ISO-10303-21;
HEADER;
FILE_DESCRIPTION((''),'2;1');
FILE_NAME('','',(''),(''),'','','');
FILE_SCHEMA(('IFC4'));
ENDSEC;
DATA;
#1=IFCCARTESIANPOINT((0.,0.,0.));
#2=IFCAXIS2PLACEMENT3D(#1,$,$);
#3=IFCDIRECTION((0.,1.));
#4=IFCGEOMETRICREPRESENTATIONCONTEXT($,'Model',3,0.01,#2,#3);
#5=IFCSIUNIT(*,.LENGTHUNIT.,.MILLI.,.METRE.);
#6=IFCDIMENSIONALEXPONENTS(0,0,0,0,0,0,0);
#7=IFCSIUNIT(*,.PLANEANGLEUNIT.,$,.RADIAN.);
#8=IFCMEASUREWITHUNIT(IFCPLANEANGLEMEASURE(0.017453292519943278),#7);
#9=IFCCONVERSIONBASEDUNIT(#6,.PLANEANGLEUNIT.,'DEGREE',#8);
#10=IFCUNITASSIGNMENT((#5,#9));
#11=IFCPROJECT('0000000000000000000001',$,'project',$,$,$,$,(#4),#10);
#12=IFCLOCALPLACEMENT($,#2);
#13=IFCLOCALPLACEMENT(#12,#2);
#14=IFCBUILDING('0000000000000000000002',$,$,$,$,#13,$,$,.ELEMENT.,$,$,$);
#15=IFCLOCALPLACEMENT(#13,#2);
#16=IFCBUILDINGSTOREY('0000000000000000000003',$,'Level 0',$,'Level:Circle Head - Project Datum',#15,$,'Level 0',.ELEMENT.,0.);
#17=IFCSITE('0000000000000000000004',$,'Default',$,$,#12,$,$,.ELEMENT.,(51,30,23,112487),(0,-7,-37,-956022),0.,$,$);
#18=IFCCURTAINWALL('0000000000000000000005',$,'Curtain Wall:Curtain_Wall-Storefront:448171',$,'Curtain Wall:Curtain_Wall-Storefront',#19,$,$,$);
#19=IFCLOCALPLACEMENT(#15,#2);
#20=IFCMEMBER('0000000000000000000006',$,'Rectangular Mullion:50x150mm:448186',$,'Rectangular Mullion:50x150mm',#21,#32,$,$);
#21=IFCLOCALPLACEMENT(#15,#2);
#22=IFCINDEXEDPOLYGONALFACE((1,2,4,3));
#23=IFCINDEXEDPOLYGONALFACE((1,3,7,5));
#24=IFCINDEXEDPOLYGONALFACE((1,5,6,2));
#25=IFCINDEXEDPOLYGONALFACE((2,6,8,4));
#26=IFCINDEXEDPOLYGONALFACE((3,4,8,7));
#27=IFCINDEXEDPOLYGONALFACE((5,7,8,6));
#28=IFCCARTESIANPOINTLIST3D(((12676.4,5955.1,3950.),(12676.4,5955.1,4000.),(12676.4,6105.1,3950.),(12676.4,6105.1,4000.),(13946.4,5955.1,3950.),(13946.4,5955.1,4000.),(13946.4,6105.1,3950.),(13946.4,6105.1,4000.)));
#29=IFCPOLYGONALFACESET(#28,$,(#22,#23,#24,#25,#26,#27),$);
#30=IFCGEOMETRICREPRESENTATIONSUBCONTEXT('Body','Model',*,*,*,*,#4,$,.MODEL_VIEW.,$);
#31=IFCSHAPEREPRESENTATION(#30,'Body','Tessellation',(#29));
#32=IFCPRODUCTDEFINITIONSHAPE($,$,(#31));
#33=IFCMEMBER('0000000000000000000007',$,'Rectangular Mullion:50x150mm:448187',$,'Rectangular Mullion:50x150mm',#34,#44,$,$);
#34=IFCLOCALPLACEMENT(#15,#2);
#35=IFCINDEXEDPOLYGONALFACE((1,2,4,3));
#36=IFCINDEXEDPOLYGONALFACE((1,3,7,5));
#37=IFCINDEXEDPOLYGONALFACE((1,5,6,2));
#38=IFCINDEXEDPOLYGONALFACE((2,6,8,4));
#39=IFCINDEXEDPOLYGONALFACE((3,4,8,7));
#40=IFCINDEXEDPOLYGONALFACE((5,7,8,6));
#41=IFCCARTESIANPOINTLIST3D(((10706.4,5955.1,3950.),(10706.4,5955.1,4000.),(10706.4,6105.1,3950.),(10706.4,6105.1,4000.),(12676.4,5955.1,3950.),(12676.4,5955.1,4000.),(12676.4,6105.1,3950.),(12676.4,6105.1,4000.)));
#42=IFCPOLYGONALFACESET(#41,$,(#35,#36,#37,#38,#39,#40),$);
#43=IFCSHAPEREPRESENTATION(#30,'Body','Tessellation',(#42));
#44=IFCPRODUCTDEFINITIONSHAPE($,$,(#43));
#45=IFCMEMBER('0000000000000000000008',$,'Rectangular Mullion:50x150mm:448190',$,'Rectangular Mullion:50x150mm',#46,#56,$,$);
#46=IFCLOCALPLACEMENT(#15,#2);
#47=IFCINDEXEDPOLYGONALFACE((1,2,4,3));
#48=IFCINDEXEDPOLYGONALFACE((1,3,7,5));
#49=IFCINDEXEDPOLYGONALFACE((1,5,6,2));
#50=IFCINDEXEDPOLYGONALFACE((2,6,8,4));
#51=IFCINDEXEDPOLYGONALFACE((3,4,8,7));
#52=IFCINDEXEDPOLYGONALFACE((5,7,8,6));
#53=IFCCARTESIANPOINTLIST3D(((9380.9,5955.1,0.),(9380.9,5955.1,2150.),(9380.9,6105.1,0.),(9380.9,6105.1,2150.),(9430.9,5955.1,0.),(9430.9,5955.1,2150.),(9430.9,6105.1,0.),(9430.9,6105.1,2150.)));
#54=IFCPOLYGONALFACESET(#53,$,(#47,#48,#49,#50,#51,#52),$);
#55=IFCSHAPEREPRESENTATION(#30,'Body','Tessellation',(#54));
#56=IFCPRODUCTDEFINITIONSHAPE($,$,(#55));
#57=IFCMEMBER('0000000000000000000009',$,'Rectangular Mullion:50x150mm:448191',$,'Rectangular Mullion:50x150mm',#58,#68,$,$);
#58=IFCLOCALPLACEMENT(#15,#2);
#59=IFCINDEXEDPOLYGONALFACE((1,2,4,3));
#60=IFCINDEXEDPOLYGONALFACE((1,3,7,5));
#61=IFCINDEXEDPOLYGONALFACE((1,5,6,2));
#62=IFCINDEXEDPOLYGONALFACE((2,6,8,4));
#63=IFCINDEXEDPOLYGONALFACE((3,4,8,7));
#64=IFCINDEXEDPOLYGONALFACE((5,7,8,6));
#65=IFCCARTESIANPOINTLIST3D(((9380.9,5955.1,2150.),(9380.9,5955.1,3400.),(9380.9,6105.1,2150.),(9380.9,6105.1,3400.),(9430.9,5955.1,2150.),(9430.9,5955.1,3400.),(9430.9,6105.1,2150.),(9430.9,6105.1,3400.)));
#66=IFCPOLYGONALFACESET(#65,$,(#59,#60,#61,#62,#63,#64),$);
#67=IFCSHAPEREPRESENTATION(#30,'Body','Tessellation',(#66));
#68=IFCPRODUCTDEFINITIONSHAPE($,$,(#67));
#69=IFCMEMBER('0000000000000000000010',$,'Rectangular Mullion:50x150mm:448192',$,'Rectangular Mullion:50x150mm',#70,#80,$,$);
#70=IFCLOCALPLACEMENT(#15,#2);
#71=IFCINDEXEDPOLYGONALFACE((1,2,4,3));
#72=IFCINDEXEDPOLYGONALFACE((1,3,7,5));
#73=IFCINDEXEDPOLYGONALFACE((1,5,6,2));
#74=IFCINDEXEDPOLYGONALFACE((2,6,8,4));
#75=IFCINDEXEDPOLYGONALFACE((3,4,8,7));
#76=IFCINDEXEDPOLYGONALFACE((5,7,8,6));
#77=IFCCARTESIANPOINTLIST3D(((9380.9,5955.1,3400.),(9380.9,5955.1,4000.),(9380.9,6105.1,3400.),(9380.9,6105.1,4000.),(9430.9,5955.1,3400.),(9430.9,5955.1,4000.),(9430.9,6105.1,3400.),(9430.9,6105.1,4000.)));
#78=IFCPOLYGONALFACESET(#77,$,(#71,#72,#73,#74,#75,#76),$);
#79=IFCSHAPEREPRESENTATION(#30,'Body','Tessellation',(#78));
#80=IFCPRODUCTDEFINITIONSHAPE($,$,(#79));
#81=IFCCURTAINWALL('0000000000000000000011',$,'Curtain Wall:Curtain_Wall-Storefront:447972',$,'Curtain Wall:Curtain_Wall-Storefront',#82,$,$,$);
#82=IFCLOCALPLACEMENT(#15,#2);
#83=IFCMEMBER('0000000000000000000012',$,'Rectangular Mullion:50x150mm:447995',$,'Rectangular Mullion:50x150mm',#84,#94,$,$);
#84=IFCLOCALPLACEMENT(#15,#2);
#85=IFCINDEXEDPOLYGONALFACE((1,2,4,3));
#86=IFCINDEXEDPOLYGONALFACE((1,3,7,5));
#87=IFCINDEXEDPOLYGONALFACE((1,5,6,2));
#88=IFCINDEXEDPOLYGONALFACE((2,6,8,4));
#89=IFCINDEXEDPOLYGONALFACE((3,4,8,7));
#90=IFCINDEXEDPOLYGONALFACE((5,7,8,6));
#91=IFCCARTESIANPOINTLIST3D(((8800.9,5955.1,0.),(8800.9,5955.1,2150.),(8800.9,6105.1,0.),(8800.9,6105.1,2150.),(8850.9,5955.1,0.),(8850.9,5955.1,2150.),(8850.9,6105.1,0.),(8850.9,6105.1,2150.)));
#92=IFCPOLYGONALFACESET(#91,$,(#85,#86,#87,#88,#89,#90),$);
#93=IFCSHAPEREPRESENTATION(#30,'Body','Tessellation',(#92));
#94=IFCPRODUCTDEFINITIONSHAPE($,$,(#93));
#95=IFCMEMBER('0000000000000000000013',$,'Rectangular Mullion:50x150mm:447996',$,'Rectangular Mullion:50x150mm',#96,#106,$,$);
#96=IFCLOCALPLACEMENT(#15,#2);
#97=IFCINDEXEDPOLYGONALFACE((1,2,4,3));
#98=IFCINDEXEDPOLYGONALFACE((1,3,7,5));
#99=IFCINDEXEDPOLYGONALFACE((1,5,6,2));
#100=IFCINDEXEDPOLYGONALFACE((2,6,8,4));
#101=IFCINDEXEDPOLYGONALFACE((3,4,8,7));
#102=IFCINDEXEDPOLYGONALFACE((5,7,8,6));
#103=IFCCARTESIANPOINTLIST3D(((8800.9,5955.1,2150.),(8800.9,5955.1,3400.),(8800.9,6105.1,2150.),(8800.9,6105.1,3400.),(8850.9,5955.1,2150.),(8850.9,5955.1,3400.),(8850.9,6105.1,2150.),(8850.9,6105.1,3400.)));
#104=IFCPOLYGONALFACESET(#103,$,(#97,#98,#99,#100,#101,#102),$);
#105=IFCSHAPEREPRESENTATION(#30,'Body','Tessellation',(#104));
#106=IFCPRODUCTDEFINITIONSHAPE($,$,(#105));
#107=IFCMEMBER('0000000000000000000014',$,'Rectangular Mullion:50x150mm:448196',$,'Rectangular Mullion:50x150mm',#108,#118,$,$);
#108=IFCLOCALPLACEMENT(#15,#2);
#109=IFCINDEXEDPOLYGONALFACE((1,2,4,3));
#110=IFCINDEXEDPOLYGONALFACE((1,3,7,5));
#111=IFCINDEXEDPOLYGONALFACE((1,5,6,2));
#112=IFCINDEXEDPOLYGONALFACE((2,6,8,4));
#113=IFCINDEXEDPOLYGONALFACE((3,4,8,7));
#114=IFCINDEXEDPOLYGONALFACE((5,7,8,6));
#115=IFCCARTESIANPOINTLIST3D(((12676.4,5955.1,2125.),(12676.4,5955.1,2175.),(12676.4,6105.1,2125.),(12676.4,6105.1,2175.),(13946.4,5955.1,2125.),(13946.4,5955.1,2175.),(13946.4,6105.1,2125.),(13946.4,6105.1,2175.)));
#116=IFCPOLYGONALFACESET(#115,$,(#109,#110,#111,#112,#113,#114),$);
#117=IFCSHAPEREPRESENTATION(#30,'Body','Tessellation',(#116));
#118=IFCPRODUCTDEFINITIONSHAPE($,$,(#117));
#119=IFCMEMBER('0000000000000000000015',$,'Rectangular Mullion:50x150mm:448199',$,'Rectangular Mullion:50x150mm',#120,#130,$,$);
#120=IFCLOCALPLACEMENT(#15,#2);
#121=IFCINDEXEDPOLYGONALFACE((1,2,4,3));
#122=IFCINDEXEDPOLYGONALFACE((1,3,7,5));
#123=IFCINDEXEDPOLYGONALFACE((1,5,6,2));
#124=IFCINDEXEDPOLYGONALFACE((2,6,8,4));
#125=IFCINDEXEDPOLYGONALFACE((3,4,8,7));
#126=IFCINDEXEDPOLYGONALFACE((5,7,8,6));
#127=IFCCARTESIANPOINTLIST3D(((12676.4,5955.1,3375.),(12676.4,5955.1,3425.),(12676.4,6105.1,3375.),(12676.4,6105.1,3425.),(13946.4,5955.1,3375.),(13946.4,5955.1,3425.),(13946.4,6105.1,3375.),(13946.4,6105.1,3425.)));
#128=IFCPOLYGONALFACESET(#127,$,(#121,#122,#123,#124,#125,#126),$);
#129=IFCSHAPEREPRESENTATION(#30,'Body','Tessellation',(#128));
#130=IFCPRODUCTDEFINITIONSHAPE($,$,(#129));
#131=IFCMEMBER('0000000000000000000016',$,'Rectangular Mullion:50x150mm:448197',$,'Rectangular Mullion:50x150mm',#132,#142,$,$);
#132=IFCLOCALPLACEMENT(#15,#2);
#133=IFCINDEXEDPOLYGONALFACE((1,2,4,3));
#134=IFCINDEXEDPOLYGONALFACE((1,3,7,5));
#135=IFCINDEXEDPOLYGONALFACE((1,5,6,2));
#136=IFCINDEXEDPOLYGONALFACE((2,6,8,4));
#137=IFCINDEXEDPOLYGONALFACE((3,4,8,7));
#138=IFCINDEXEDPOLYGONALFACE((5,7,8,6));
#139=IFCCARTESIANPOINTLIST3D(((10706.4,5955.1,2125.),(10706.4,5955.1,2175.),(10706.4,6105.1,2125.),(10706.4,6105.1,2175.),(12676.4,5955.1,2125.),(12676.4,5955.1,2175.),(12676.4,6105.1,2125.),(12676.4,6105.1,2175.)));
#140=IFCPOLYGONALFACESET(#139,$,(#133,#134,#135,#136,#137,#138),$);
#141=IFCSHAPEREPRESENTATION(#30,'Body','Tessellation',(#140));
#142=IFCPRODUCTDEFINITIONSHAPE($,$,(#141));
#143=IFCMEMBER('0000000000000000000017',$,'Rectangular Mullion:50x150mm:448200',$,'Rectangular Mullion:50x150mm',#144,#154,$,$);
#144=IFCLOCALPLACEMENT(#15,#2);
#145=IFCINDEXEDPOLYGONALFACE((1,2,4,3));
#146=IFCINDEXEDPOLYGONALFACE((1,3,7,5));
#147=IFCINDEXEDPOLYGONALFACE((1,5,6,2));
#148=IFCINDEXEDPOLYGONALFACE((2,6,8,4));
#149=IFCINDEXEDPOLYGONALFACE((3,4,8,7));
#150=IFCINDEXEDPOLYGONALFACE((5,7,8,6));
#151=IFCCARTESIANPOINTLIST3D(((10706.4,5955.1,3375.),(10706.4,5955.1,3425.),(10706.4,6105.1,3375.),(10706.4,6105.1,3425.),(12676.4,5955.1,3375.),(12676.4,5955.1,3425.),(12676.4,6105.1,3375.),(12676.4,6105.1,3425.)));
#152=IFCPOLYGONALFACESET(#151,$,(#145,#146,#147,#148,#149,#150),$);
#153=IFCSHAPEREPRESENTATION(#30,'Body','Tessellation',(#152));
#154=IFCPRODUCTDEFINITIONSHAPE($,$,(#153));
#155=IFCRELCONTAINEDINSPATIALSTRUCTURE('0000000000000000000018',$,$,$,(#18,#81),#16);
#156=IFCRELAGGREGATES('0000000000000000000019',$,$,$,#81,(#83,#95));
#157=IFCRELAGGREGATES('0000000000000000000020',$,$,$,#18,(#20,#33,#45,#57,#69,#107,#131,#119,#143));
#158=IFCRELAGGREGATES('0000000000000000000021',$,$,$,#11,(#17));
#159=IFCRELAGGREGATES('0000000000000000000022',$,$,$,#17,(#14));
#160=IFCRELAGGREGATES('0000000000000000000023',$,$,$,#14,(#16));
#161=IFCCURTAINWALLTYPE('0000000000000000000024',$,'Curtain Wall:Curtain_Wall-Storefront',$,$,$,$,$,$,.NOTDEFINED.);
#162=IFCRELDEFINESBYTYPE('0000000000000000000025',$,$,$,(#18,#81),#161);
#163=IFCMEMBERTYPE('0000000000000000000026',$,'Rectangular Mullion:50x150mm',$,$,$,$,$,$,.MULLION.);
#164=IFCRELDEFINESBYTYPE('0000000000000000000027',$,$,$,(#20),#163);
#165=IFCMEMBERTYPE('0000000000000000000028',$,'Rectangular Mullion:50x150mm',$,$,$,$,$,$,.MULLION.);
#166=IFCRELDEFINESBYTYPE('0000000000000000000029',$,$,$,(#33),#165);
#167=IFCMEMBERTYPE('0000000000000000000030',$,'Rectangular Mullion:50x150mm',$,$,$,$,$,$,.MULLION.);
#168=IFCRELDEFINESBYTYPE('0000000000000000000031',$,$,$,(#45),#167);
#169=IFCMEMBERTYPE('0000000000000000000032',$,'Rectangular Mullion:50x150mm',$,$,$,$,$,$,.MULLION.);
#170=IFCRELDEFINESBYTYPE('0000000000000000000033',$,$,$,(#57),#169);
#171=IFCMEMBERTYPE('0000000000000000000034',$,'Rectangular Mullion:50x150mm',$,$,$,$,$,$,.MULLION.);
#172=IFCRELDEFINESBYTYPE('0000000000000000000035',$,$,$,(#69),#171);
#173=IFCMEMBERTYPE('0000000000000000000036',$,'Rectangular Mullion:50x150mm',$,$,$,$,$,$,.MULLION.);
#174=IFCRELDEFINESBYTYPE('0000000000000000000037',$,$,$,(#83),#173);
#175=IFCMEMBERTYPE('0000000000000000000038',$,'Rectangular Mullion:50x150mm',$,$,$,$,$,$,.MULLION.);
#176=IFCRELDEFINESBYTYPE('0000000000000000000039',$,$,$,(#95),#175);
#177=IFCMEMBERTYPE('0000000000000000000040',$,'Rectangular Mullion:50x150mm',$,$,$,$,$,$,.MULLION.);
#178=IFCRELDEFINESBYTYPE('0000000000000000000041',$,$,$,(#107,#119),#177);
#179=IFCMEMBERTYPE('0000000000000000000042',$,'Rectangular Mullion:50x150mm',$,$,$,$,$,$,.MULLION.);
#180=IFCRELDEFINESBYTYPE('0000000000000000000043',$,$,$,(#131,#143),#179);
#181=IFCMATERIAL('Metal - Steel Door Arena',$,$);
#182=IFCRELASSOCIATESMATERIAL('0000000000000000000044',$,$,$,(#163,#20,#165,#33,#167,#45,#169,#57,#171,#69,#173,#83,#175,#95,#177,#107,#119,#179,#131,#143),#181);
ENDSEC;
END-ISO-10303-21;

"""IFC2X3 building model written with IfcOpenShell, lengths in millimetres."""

from ifc_helpers import new_model, entity, si_unit, converted_unit, direction, frame, origin, origin_2d_with_axis, place, context, subcontext, project, spatial, rectangle, extrude, source, transform, mapped, material, type_object, type_shapes, element, aggregate, save


model = new_model("IFC2X3")

# Units and contexts
model_context = context("Model", 3, precision=0.01, world=origin(), true_north=direction((0.0, 1.0)))
body_context = subcontext(model_context, "Body", "Model", "MODEL_VIEW")
ifc_project = project(units=[si_unit("LENGTHUNIT", "METRE", prefix="MILLI"), converted_unit("PLANEANGLEUNIT", "DEGREE", entity("IfcPlaneAngleMeasure", 0.017453292519943278), si_unit("PLANEANGLEUNIT", "RADIAN"), dimensions=[0, 0, 0, 0, 0, 0, 0])], contexts=[model_context])

# Site, building, storey
site_placement = place(None, origin())
site = spatial("IfcSite", under=ifc_project, at=site_placement, Name="Default", CompositionType="ELEMENT", RefLatitude=(51, 30, 23, 112487), RefLongitude=(0, -7, -37, -956022), RefElevation=0.0)
building_placement = place(site_placement, origin())
building = spatial("IfcBuilding", under=site, at=building_placement, CompositionType="ELEMENT")
storey_placement = place(building_placement, origin())
storey = spatial("IfcBuildingStorey", under=building, at=storey_placement, Name="Level 0", ObjectType="Level:Circle Head - Project Datum", LongName="Level 0", CompositionType="ELEMENT", Elevation=0.0)

# Curtain walls, members
curtain_wall_type = type_object("IfcCurtainWallType", Name="Curtain Wall:Curtain_Wall-Storefront", PredefinedType="NOTDEFINED")
curtain_wall_1_placement = place(storey_placement, origin())
curtain_wall_1 = element("IfcCurtainWall", 1, at=curtain_wall_1_placement, inside=storey, type_object=curtain_wall_type, Name="Curtain Wall:Curtain_Wall-Storefront:448171", ObjectType="Curtain Wall:Curtain_Wall-Storefront")
ifc_material_1 = material(Name="Metal - Steel Door Arena")
member_type_1 = type_object("IfcMemberType", Name="Rectangular Mullion:50x150mm", PredefinedType="MULLION", material=ifc_material_1)
shared_shape_1 = source(origin(), body_context, "Body", "SweptSolid", [
    extrude(rectangle(XDim=50.0, YDim=150.0, at=origin_2d_with_axis()), frame((-25.0, 0.0, -1270.0), z_axis=(0.0, 0.0, 1.0), x_axis=(-1.0, 0.0, 0.0)), (0.0, 0.0, 1.0), 1270.0),
])
type_shapes(member_type_1, [shared_shape_1])
member_1_placement = place(curtain_wall_1_placement, frame((12676.4, 6030.1, 4000.0), z_axis=(-1.0, 0.0, 0.0), x_axis=(0.0, 0.0, 1.0)))
member_1 = element("IfcMember", 2, at=member_1_placement, type_object=member_type_1, material=ifc_material_1, Name="Rectangular Mullion:50x150mm:448186", ObjectType="Rectangular Mullion:50x150mm", context=body_context, shape_type="MappedRepresentation", body=[
    mapped(shared_shape_1, transform((0.0, 0.0, 0.0), scale=1.0)),
])
member_type_2 = type_object("IfcMemberType", Name="Rectangular Mullion:50x150mm", PredefinedType="MULLION", material=ifc_material_1)
shared_shape_2 = source(origin(), body_context, "Body", "SweptSolid", [
    extrude(rectangle(XDim=50.0, YDim=150.0, at=origin_2d_with_axis()), frame((-25.0, 0.0, -1970.0), z_axis=(0.0, 0.0, 1.0), x_axis=(-1.0, 0.0, 0.0)), (0.0, 0.0, 1.0), 1970.0),
])
type_shapes(member_type_2, [shared_shape_2])
member_2_placement = place(curtain_wall_1_placement, frame((10706.4, 6030.1, 4000.0), z_axis=(-1.0, 0.0, 0.0), x_axis=(0.0, 0.0, 1.0)))
member_2 = element("IfcMember", 3, at=member_2_placement, type_object=member_type_2, material=ifc_material_1, Name="Rectangular Mullion:50x150mm:448187", ObjectType="Rectangular Mullion:50x150mm", context=body_context, shape_type="MappedRepresentation", body=[
    mapped(shared_shape_2, transform((0.0, 0.0, 0.0), scale=1.0)),
])
member_type_3 = type_object("IfcMemberType", Name="Rectangular Mullion:50x150mm", PredefinedType="MULLION", material=ifc_material_1)
shared_shape_3 = source(origin(), body_context, "Body", "SweptSolid", [
    extrude(rectangle(XDim=50.0, YDim=150.0, at=origin_2d_with_axis()), frame((-25.0, 0.0, -2150.0), z_axis=(0.0, 0.0, 1.0), x_axis=(-1.0, 0.0, 0.0)), (0.0, 0.0, 1.0), 2150.0),
])
type_shapes(member_type_3, [shared_shape_3])
member_3_placement = place(curtain_wall_1_placement, frame((9380.9, 6030.1, 0.0), z_axis=(0.0, 0.0, -1.0), x_axis=(-1.0, 0.0, 0.0)))
member_3 = element("IfcMember", 4, at=member_3_placement, type_object=member_type_3, material=ifc_material_1, Name="Rectangular Mullion:50x150mm:448190", ObjectType="Rectangular Mullion:50x150mm", context=body_context, shape_type="MappedRepresentation", body=[
    mapped(shared_shape_3, transform((0.0, 0.0, 0.0), scale=1.0)),
])
member_type_4 = type_object("IfcMemberType", Name="Rectangular Mullion:50x150mm", PredefinedType="MULLION", material=ifc_material_1)
shared_shape_4 = source(origin(), body_context, "Body", "SweptSolid", [
    extrude(rectangle(XDim=50.0, YDim=150.0, at=origin_2d_with_axis()), frame((-25.0, 0.0, -1250.0), z_axis=(0.0, 0.0, 1.0), x_axis=(-1.0, 0.0, 0.0)), (0.0, 0.0, 1.0), 1250.0),
])
type_shapes(member_type_4, [shared_shape_4])
member_4_placement = place(curtain_wall_1_placement, frame((9380.9, 6030.1, 2150.0), z_axis=(0.0, 0.0, -1.0), x_axis=(-1.0, 0.0, 0.0)))
member_4 = element("IfcMember", 5, at=member_4_placement, type_object=member_type_4, material=ifc_material_1, Name="Rectangular Mullion:50x150mm:448191", ObjectType="Rectangular Mullion:50x150mm", context=body_context, shape_type="MappedRepresentation", body=[
    mapped(shared_shape_4, transform((0.0, 0.0, 0.0), scale=1.0)),
])
member_type_5 = type_object("IfcMemberType", Name="Rectangular Mullion:50x150mm", PredefinedType="MULLION", material=ifc_material_1)
shared_shape_5 = source(origin(), body_context, "Body", "SweptSolid", [
    extrude(rectangle(XDim=50.0, YDim=150.0, at=origin_2d_with_axis()), frame((-25.0, 0.0, -600.0), z_axis=(0.0, 0.0, 1.0), x_axis=(-1.0, 0.0, 0.0)), (0.0, 0.0, 1.0), 600.0),
])
type_shapes(member_type_5, [shared_shape_5])
member_5_placement = place(curtain_wall_1_placement, frame((9380.9, 6030.1, 3400.0), z_axis=(0.0, 0.0, -1.0), x_axis=(-1.0, 0.0, 0.0)))
member_5 = element("IfcMember", 6, at=member_5_placement, type_object=member_type_5, material=ifc_material_1, Name="Rectangular Mullion:50x150mm:448192", ObjectType="Rectangular Mullion:50x150mm", context=body_context, shape_type="MappedRepresentation", body=[
    mapped(shared_shape_5, transform((0.0, 0.0, 0.0), scale=1.0)),
])
curtain_wall_2_placement = place(storey_placement, origin())
curtain_wall_2 = element("IfcCurtainWall", 7, at=curtain_wall_2_placement, inside=storey, type_object=curtain_wall_type, Name="Curtain Wall:Curtain_Wall-Storefront:447972", ObjectType="Curtain Wall:Curtain_Wall-Storefront")
member_type_6 = type_object("IfcMemberType", Name="Rectangular Mullion:50x150mm", PredefinedType="MULLION", material=ifc_material_1)
shared_shape_6 = source(origin(), body_context, "Body", "SweptSolid", [
    extrude(rectangle(XDim=50.0, YDim=150.0, at=origin_2d_with_axis()), frame((-25.0, 0.0, -2150.0), z_axis=(0.0, 0.0, 1.0), x_axis=(-1.0, 0.0, 0.0)), (0.0, 0.0, 1.0), 2150.0),
])
type_shapes(member_type_6, [shared_shape_6])
member_6_placement = place(curtain_wall_2_placement, frame((8850.9, 6030.1, 2150.0)))
member_6 = element("IfcMember", 8, at=member_6_placement, type_object=member_type_6, material=ifc_material_1, Name="Rectangular Mullion:50x150mm:447995", ObjectType="Rectangular Mullion:50x150mm", context=body_context, shape_type="MappedRepresentation", body=[
    mapped(shared_shape_6, transform((0.0, 0.0, 0.0), scale=1.0)),
])
member_type_7 = type_object("IfcMemberType", Name="Rectangular Mullion:50x150mm", PredefinedType="MULLION", material=ifc_material_1)
shared_shape_7 = source(origin(), body_context, "Body", "SweptSolid", [
    extrude(rectangle(XDim=50.0, YDim=150.0, at=origin_2d_with_axis()), frame((-25.0, 0.0, -1250.0), z_axis=(0.0, 0.0, 1.0), x_axis=(-1.0, 0.0, 0.0)), (0.0, 0.0, 1.0), 1250.0),
])
type_shapes(member_type_7, [shared_shape_7])
member_7_placement = place(curtain_wall_2_placement, frame((8850.9, 6030.1, 3400.0)))
member_7 = element("IfcMember", 9, at=member_7_placement, type_object=member_type_7, material=ifc_material_1, Name="Rectangular Mullion:50x150mm:447996", ObjectType="Rectangular Mullion:50x150mm", context=body_context, shape_type="MappedRepresentation", body=[
    mapped(shared_shape_7, transform((0.0, 0.0, 0.0), scale=1.0)),
])
aggregate(curtain_wall_2, [member_6, member_7])

# Members
member_type_8 = type_object("IfcMemberType", Name="Rectangular Mullion:50x150mm", PredefinedType="MULLION", material=ifc_material_1)
shared_shape_8 = source(origin(), body_context, "Body", "SweptSolid", [
    extrude(rectangle(XDim=50.0, YDim=150.0, at=origin_2d_with_axis()), frame((0.0, 0.0, -1270.0), z_axis=(0.0, 0.0, 1.0), x_axis=(-1.0, 0.0, 0.0)), (0.0, 0.0, 1.0), 1270.0),
])
type_shapes(member_type_8, [shared_shape_8])
member_8_placement = place(curtain_wall_1_placement, frame((12676.4, 6030.1, 2150.0), z_axis=(-1.0, 0.0, 0.0), x_axis=(0.0, 0.0, 1.0)))
member_8 = element("IfcMember", 10, at=member_8_placement, type_object=member_type_8, material=ifc_material_1, Name="Rectangular Mullion:50x150mm:448196", ObjectType="Rectangular Mullion:50x150mm", context=body_context, shape_type="MappedRepresentation", body=[
    mapped(shared_shape_8, transform((0.0, 0.0, 0.0), scale=1.0)),
])
member_9_placement = place(curtain_wall_1_placement, frame((12676.4, 6030.1, 3400.0), z_axis=(-1.0, 0.0, 0.0), x_axis=(0.0, 0.0, 1.0)))
member_9 = element("IfcMember", 11, at=member_9_placement, type_object=member_type_8, material=ifc_material_1, Name="Rectangular Mullion:50x150mm:448199", ObjectType="Rectangular Mullion:50x150mm", context=body_context, shape_type="MappedRepresentation", body=[
    mapped(shared_shape_8, transform((0.0, 0.0, 0.0), scale=1.0)),
])
member_type_9 = type_object("IfcMemberType", Name="Rectangular Mullion:50x150mm", PredefinedType="MULLION", material=ifc_material_1)
shared_shape_9 = source(origin(), body_context, "Body", "SweptSolid", [
    extrude(rectangle(XDim=50.0, YDim=150.0, at=origin_2d_with_axis()), frame((0.0, 0.0, -1970.0), z_axis=(0.0, 0.0, 1.0), x_axis=(-1.0, 0.0, 0.0)), (0.0, 0.0, 1.0), 1970.0),
])
type_shapes(member_type_9, [shared_shape_9])
member_10_placement = place(curtain_wall_1_placement, frame((10706.4, 6030.1, 2150.0), z_axis=(-1.0, 0.0, 0.0), x_axis=(0.0, 0.0, 1.0)))
member_10 = element("IfcMember", 12, at=member_10_placement, type_object=member_type_9, material=ifc_material_1, Name="Rectangular Mullion:50x150mm:448197", ObjectType="Rectangular Mullion:50x150mm", context=body_context, shape_type="MappedRepresentation", body=[
    mapped(shared_shape_9, transform((0.0, 0.0, 0.0), scale=1.0)),
])
member_11_placement = place(curtain_wall_1_placement, frame((10706.4, 6030.1, 3400.0), z_axis=(-1.0, 0.0, 0.0), x_axis=(0.0, 0.0, 1.0)))
member_11 = element("IfcMember", 13, at=member_11_placement, type_object=member_type_9, material=ifc_material_1, Name="Rectangular Mullion:50x150mm:448200", ObjectType="Rectangular Mullion:50x150mm", context=body_context, shape_type="MappedRepresentation", body=[
    mapped(shared_shape_9, transform((0.0, 0.0, 0.0), scale=1.0)),
])

aggregate(curtain_wall_1, [member_1, member_2, member_3, member_4, member_5, member_8, member_10, member_9, member_11])

save(model, "model.ifc")
